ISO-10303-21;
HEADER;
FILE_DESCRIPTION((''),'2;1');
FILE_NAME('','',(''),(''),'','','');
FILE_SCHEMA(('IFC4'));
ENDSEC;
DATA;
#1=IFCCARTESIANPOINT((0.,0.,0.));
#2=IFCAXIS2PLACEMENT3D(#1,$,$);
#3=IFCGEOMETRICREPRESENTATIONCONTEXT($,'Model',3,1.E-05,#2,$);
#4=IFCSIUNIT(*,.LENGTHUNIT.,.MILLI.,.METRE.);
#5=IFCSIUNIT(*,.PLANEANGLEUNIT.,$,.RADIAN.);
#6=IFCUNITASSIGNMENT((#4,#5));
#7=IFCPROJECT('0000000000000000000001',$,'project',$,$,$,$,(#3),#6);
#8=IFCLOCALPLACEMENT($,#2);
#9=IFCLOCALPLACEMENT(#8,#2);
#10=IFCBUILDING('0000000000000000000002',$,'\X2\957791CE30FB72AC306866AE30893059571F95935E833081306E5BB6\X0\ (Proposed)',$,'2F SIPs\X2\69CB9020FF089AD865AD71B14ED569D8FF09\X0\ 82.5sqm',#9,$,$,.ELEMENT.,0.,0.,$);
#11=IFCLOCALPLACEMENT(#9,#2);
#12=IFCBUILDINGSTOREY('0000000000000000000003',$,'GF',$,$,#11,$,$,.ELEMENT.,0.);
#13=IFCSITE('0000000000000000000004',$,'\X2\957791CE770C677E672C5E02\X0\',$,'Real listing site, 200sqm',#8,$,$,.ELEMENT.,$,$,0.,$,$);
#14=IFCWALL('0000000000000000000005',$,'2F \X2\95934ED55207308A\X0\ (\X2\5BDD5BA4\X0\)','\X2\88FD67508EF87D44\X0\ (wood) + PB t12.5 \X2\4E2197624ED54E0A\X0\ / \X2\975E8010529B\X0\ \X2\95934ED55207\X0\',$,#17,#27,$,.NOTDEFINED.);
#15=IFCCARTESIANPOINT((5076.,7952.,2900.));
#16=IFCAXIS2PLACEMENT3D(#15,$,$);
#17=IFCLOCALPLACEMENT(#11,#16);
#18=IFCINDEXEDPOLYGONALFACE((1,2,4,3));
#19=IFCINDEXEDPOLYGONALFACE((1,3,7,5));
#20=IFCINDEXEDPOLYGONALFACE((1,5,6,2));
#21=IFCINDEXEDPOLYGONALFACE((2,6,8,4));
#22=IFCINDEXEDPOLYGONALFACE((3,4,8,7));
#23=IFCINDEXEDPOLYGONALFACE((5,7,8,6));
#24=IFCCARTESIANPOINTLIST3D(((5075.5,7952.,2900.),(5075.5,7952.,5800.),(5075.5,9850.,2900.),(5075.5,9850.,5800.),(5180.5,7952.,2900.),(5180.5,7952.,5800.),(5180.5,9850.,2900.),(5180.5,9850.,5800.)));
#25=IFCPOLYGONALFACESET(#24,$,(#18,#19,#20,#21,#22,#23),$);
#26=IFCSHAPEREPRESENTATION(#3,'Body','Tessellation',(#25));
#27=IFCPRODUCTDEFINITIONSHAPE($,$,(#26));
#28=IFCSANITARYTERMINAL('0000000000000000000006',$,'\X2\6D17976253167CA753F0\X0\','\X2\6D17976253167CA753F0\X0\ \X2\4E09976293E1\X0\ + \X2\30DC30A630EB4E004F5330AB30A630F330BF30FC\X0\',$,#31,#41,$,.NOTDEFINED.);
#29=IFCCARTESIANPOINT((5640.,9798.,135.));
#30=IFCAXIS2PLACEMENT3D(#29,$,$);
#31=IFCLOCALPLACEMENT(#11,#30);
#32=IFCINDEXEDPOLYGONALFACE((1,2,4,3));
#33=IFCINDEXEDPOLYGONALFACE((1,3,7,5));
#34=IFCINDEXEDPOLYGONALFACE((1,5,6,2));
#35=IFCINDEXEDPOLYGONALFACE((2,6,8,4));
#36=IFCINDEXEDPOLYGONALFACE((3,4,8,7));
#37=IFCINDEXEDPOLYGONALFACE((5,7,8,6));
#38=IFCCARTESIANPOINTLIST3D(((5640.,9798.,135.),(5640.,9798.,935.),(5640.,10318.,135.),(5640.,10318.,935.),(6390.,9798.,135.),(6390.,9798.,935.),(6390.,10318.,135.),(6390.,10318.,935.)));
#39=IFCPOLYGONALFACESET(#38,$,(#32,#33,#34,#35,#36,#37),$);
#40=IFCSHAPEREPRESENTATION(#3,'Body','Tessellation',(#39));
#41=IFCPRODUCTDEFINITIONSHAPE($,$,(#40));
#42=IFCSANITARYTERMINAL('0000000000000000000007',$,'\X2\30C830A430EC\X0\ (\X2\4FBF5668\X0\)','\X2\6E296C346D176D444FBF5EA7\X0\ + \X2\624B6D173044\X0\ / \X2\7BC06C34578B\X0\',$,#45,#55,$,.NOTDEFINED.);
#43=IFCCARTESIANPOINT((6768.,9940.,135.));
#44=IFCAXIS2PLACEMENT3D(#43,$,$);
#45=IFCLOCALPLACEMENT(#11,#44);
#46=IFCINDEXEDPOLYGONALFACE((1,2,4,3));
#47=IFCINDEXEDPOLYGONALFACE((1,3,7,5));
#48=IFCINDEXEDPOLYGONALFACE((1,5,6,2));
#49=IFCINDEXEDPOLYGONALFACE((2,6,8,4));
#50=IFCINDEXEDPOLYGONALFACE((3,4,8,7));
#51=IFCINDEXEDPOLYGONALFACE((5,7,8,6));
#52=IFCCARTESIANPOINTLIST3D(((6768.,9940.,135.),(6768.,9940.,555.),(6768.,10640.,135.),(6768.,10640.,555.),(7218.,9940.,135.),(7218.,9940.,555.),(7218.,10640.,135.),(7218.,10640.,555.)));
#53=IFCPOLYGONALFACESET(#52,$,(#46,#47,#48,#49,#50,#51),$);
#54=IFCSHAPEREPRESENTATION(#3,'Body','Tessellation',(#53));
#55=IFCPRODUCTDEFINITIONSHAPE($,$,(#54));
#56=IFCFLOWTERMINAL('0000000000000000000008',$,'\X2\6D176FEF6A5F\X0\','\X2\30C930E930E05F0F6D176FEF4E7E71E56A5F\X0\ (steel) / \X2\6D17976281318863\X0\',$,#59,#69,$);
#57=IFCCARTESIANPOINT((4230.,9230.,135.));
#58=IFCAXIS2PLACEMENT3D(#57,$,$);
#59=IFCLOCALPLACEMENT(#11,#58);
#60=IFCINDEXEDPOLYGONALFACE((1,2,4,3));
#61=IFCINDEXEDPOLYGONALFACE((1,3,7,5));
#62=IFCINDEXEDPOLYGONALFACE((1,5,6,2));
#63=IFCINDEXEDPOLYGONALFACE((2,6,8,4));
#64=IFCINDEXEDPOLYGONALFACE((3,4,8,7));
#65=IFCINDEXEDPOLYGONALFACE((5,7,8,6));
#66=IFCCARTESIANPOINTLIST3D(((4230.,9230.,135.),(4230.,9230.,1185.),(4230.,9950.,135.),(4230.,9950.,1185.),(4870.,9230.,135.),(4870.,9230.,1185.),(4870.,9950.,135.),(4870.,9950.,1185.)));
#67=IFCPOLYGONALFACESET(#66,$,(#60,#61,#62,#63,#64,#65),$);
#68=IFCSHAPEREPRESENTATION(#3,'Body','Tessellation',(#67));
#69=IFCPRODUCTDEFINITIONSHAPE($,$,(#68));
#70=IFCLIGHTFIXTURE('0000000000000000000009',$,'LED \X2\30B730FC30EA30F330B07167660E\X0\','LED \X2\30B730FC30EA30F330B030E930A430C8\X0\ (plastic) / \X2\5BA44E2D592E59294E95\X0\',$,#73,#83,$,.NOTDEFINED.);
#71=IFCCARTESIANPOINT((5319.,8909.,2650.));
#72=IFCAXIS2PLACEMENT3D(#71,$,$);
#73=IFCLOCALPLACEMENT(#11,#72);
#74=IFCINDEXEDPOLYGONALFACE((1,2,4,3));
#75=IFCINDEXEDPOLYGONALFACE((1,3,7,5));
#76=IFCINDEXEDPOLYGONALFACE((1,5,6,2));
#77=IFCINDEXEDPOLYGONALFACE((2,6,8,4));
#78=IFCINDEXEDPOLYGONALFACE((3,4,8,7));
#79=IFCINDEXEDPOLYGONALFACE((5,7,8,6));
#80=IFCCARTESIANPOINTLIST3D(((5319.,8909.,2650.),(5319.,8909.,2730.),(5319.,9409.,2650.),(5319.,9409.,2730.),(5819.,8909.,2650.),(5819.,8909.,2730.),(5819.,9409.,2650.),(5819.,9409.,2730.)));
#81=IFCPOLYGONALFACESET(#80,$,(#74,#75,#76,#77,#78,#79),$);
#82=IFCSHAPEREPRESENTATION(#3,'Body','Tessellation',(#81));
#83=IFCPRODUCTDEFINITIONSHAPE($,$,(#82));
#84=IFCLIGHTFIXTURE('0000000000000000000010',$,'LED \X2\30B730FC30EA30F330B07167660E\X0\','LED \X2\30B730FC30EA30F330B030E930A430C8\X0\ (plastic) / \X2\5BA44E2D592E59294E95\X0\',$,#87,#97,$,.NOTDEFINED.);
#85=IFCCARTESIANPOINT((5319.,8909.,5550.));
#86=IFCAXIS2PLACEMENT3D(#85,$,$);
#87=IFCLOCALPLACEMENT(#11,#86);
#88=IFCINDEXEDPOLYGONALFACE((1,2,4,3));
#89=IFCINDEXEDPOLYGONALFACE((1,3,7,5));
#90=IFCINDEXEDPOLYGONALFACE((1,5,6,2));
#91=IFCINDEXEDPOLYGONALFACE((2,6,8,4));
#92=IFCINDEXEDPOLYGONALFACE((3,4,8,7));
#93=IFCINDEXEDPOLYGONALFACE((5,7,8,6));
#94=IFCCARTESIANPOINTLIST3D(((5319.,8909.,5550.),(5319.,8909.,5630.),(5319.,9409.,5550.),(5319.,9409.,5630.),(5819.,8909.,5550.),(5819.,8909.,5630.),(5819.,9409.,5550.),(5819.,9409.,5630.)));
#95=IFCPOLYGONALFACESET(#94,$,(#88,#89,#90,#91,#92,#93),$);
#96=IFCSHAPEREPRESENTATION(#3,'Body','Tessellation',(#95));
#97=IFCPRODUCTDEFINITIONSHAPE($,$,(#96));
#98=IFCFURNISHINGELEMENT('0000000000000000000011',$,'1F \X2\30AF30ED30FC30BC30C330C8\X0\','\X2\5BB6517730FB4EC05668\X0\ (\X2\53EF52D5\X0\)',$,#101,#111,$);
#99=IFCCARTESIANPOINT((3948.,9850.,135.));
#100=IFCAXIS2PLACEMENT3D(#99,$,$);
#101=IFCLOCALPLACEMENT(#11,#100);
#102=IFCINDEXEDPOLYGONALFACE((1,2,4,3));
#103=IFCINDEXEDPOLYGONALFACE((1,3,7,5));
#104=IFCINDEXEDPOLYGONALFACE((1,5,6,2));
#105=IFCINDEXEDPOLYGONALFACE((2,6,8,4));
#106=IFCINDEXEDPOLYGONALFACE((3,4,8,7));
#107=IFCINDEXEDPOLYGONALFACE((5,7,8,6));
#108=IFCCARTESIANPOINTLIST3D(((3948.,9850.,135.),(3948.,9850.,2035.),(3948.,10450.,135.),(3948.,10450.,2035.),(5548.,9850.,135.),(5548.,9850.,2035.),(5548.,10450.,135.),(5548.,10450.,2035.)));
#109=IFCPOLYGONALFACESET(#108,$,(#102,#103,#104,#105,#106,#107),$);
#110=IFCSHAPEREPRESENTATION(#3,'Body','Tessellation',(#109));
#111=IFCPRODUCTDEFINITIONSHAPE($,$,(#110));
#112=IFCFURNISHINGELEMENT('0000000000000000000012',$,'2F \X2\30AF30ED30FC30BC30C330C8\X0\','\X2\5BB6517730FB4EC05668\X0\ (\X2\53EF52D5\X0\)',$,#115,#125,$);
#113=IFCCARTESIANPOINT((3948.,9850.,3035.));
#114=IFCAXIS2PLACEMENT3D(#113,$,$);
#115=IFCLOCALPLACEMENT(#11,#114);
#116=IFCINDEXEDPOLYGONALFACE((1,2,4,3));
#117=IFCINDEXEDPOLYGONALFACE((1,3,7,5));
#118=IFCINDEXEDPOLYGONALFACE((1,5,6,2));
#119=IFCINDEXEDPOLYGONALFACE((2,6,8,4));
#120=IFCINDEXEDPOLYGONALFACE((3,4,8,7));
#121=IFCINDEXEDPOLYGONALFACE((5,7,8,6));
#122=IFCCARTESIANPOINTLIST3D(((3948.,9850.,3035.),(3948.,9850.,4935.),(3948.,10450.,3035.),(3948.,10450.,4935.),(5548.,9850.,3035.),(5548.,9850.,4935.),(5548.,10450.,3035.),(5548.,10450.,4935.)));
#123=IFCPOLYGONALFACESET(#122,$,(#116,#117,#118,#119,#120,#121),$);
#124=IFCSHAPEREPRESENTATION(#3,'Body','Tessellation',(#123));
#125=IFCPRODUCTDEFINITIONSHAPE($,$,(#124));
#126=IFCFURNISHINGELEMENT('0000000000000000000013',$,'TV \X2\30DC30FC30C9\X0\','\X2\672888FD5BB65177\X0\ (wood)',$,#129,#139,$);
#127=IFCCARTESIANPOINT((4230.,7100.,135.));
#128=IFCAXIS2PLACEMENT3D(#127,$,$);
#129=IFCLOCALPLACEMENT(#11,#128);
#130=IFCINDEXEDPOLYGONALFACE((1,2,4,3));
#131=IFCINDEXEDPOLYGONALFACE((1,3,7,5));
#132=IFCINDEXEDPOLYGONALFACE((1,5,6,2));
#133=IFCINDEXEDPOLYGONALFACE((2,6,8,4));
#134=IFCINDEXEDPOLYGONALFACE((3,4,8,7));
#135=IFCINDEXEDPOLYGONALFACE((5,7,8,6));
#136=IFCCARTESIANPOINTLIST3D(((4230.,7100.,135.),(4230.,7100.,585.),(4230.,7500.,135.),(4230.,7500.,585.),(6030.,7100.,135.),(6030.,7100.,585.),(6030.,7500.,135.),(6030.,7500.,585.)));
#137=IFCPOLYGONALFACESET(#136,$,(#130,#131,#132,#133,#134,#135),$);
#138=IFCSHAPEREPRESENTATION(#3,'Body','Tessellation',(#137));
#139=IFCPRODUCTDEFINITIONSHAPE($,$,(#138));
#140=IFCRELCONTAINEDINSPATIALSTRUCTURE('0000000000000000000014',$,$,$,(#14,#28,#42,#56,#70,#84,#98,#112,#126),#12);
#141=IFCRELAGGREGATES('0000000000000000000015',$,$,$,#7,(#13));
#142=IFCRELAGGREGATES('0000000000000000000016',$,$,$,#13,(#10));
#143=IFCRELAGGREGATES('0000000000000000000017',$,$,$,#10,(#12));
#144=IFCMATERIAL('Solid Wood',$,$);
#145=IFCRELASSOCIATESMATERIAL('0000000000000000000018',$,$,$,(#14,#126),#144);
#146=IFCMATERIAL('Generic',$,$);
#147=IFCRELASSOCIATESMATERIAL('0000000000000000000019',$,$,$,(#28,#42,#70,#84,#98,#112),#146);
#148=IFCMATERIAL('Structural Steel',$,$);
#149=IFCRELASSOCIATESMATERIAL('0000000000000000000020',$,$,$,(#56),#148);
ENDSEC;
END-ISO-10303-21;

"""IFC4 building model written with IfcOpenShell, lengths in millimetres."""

from ifc_helpers import new_model, si_unit, frame, frame_2d, origin, place, context, project, spatial, rectangle, extrude, material, element, save


model = new_model("IFC4")

# Units and contexts
model_context = context("Model", 3, precision=1e-05, world=origin())
ifc_project = project(units=[si_unit("LENGTHUNIT", "METRE", prefix="MILLI"), si_unit("PLANEANGLEUNIT", "RADIAN")], contexts=[model_context])

# Site, building, storey
site_placement = place(None, origin())
site = spatial("IfcSite", under=ifc_project, at=site_placement, Name="長野県松本市", ObjectType="Real listing site, 200sqm", CompositionType="ELEMENT", RefElevation=0.0)
building_placement = place(site_placement, origin())
building = spatial("IfcBuilding", under=site, at=building_placement, Name="長野・犬と暮らす土間広めの家 (Proposed)", ObjectType="2F SIPs構造（高断熱仕様） 82.5sqm", CompositionType="ELEMENT", ElevationOfRefHeight=0.0, ElevationOfTerrain=0.0)
storey_placement = place(building_placement, origin())
storey = spatial("IfcBuildingStorey", under=building, at=storey_placement, Name="GF", CompositionType="ELEMENT", Elevation=0.0)

# Shared definitions
ifc_material_1 = material(Name="Solid Wood")

# Wall
wall_1_placement = place(storey_placement, frame((5076.0, 7952.0, 2900.0)))
element("IfcWall", 1, at=wall_1_placement, inside=storey, material=ifc_material_1, Name="2F 間仕切り (寝室)", Description="製材軸組 (wood) + PB t12.5 両面仕上 / 非耐力 間仕切", PredefinedType="NOTDEFINED", context=model_context, shape_type="SweptSolid", body=[
    extrude(rectangle(XDim=105.0, YDim=1898.0, at=frame_2d((52.0, 949.0))), frame((5076.0, 7952.0, 2900.0)), (0.0, 0.0, 1.0), 2900.0),
])

# Sanitary terminals
ifc_material_2 = material(Name="Generic")
sanitary_terminal_1_placement = place(storey_placement, frame((5640.0, 9798.0, 135.0)))
element("IfcSanitaryTerminal", 2, at=sanitary_terminal_1_placement, inside=storey, material=ifc_material_2, Name="洗面化粧台", Description="洗面化粧台 三面鏡 + ボウル一体カウンター", PredefinedType="NOTDEFINED", context=model_context, shape_type="SweptSolid", body=[
    extrude(rectangle(XDim=750.0, YDim=520.0, at=frame_2d((375.0, 260.0))), frame((5640.0, 9798.0, 135.0)), (0.0, 0.0, 1.0), 800.0),
])
sanitary_terminal_2_placement = place(storey_placement, frame((6768.0, 9940.0, 135.0)))
element("IfcSanitaryTerminal", 3, at=sanitary_terminal_2_placement, inside=storey, material=ifc_material_2, Name="トイレ (便器)", Description="温水洗浄便座 + 手洗い / 節水型", PredefinedType="NOTDEFINED", context=model_context, shape_type="SweptSolid", body=[
    extrude(rectangle(XDim=450.0, YDim=700.0, at=frame_2d((225.0, 350.0))), frame((6768.0, 9940.0, 135.0)), (0.0, 0.0, 1.0), 420.0),
])

# Flow terminal
ifc_material_3 = material(Name="Structural Steel")
flow_terminal_placement = place(storey_placement, frame((4230.0, 9230.0, 135.0)))
element("IfcFlowTerminal", 4, at=flow_terminal_placement, inside=storey, material=ifc_material_3, Name="洗濯機", Description="ドラム式洗濯乾燥機 (steel) / 洗面脱衣", context=model_context, shape_type="SweptSolid", body=[
    extrude(rectangle(XDim=640.0, YDim=720.0, at=frame_2d((320.0, 360.0))), frame((4230.0, 9230.0, 135.0)), (0.0, 0.0, 1.0), 1050.0),
])

# Light fixtures
light_fixture_1_placement = place(storey_placement, frame((5319.0, 8909.0, 2650.0)))
element("IfcLightFixture", 5, at=light_fixture_1_placement, inside=storey, material=ifc_material_2, Name="LED シーリング照明", Description="LED シーリングライト (plastic) / 室中央天井", PredefinedType="NOTDEFINED", context=model_context, shape_type="SweptSolid", body=[
    extrude(rectangle(XDim=500.0, YDim=500.0, at=frame_2d((250.0, 250.0))), frame((5319.0, 8909.0, 2650.0)), (0.0, 0.0, 1.0), 80.0),
])
light_fixture_2_placement = place(storey_placement, frame((5319.0, 8909.0, 5550.0)))
element("IfcLightFixture", 6, at=light_fixture_2_placement, inside=storey, material=ifc_material_2, Name="LED シーリング照明", Description="LED シーリングライト (plastic) / 室中央天井", PredefinedType="NOTDEFINED", context=model_context, shape_type="SweptSolid", body=[
    extrude(rectangle(XDim=500.0, YDim=500.0, at=frame_2d((250.0, 250.0))), frame((5319.0, 8909.0, 5550.0)), (0.0, 0.0, 1.0), 80.0),
])

# Furnishing elements
furnishing_1_placement = place(storey_placement, frame((3948.0, 9850.0, 135.0)))
element("IfcFurnishingElement", 7, at=furnishing_1_placement, inside=storey, material=ifc_material_2, Name="1F クローゼット", Description="家具・什器 (可動)", context=model_context, shape_type="SweptSolid", body=[
    extrude(rectangle(XDim=1600.0, YDim=600.0, at=frame_2d((800.0, 300.0))), frame((3948.0, 9850.0, 135.0)), (0.0, 0.0, 1.0), 1900.0),
])
furnishing_2_placement = place(storey_placement, frame((3948.0, 9850.0, 3035.0)))
element("IfcFurnishingElement", 8, at=furnishing_2_placement, inside=storey, material=ifc_material_2, Name="2F クローゼット", Description="家具・什器 (可動)", context=model_context, shape_type="SweptSolid", body=[
    extrude(rectangle(XDim=1600.0, YDim=600.0, at=frame_2d((800.0, 300.0))), frame((3948.0, 9850.0, 3035.0)), (0.0, 0.0, 1.0), 1900.0),
])
furnishing_3_placement = place(storey_placement, frame((4230.0, 7100.0, 135.0)))
element("IfcFurnishingElement", 9, at=furnishing_3_placement, inside=storey, material=ifc_material_1, Name="TV ボード", Description="木製家具 (wood)", context=model_context, shape_type="SweptSolid", body=[
    extrude(rectangle(XDim=1800.0, YDim=400.0, at=frame_2d((900.0, 200.0))), frame((4230.0, 7100.0, 135.0)), (0.0, 0.0, 1.0), 450.0),
])

save(model, "model.ifc")
